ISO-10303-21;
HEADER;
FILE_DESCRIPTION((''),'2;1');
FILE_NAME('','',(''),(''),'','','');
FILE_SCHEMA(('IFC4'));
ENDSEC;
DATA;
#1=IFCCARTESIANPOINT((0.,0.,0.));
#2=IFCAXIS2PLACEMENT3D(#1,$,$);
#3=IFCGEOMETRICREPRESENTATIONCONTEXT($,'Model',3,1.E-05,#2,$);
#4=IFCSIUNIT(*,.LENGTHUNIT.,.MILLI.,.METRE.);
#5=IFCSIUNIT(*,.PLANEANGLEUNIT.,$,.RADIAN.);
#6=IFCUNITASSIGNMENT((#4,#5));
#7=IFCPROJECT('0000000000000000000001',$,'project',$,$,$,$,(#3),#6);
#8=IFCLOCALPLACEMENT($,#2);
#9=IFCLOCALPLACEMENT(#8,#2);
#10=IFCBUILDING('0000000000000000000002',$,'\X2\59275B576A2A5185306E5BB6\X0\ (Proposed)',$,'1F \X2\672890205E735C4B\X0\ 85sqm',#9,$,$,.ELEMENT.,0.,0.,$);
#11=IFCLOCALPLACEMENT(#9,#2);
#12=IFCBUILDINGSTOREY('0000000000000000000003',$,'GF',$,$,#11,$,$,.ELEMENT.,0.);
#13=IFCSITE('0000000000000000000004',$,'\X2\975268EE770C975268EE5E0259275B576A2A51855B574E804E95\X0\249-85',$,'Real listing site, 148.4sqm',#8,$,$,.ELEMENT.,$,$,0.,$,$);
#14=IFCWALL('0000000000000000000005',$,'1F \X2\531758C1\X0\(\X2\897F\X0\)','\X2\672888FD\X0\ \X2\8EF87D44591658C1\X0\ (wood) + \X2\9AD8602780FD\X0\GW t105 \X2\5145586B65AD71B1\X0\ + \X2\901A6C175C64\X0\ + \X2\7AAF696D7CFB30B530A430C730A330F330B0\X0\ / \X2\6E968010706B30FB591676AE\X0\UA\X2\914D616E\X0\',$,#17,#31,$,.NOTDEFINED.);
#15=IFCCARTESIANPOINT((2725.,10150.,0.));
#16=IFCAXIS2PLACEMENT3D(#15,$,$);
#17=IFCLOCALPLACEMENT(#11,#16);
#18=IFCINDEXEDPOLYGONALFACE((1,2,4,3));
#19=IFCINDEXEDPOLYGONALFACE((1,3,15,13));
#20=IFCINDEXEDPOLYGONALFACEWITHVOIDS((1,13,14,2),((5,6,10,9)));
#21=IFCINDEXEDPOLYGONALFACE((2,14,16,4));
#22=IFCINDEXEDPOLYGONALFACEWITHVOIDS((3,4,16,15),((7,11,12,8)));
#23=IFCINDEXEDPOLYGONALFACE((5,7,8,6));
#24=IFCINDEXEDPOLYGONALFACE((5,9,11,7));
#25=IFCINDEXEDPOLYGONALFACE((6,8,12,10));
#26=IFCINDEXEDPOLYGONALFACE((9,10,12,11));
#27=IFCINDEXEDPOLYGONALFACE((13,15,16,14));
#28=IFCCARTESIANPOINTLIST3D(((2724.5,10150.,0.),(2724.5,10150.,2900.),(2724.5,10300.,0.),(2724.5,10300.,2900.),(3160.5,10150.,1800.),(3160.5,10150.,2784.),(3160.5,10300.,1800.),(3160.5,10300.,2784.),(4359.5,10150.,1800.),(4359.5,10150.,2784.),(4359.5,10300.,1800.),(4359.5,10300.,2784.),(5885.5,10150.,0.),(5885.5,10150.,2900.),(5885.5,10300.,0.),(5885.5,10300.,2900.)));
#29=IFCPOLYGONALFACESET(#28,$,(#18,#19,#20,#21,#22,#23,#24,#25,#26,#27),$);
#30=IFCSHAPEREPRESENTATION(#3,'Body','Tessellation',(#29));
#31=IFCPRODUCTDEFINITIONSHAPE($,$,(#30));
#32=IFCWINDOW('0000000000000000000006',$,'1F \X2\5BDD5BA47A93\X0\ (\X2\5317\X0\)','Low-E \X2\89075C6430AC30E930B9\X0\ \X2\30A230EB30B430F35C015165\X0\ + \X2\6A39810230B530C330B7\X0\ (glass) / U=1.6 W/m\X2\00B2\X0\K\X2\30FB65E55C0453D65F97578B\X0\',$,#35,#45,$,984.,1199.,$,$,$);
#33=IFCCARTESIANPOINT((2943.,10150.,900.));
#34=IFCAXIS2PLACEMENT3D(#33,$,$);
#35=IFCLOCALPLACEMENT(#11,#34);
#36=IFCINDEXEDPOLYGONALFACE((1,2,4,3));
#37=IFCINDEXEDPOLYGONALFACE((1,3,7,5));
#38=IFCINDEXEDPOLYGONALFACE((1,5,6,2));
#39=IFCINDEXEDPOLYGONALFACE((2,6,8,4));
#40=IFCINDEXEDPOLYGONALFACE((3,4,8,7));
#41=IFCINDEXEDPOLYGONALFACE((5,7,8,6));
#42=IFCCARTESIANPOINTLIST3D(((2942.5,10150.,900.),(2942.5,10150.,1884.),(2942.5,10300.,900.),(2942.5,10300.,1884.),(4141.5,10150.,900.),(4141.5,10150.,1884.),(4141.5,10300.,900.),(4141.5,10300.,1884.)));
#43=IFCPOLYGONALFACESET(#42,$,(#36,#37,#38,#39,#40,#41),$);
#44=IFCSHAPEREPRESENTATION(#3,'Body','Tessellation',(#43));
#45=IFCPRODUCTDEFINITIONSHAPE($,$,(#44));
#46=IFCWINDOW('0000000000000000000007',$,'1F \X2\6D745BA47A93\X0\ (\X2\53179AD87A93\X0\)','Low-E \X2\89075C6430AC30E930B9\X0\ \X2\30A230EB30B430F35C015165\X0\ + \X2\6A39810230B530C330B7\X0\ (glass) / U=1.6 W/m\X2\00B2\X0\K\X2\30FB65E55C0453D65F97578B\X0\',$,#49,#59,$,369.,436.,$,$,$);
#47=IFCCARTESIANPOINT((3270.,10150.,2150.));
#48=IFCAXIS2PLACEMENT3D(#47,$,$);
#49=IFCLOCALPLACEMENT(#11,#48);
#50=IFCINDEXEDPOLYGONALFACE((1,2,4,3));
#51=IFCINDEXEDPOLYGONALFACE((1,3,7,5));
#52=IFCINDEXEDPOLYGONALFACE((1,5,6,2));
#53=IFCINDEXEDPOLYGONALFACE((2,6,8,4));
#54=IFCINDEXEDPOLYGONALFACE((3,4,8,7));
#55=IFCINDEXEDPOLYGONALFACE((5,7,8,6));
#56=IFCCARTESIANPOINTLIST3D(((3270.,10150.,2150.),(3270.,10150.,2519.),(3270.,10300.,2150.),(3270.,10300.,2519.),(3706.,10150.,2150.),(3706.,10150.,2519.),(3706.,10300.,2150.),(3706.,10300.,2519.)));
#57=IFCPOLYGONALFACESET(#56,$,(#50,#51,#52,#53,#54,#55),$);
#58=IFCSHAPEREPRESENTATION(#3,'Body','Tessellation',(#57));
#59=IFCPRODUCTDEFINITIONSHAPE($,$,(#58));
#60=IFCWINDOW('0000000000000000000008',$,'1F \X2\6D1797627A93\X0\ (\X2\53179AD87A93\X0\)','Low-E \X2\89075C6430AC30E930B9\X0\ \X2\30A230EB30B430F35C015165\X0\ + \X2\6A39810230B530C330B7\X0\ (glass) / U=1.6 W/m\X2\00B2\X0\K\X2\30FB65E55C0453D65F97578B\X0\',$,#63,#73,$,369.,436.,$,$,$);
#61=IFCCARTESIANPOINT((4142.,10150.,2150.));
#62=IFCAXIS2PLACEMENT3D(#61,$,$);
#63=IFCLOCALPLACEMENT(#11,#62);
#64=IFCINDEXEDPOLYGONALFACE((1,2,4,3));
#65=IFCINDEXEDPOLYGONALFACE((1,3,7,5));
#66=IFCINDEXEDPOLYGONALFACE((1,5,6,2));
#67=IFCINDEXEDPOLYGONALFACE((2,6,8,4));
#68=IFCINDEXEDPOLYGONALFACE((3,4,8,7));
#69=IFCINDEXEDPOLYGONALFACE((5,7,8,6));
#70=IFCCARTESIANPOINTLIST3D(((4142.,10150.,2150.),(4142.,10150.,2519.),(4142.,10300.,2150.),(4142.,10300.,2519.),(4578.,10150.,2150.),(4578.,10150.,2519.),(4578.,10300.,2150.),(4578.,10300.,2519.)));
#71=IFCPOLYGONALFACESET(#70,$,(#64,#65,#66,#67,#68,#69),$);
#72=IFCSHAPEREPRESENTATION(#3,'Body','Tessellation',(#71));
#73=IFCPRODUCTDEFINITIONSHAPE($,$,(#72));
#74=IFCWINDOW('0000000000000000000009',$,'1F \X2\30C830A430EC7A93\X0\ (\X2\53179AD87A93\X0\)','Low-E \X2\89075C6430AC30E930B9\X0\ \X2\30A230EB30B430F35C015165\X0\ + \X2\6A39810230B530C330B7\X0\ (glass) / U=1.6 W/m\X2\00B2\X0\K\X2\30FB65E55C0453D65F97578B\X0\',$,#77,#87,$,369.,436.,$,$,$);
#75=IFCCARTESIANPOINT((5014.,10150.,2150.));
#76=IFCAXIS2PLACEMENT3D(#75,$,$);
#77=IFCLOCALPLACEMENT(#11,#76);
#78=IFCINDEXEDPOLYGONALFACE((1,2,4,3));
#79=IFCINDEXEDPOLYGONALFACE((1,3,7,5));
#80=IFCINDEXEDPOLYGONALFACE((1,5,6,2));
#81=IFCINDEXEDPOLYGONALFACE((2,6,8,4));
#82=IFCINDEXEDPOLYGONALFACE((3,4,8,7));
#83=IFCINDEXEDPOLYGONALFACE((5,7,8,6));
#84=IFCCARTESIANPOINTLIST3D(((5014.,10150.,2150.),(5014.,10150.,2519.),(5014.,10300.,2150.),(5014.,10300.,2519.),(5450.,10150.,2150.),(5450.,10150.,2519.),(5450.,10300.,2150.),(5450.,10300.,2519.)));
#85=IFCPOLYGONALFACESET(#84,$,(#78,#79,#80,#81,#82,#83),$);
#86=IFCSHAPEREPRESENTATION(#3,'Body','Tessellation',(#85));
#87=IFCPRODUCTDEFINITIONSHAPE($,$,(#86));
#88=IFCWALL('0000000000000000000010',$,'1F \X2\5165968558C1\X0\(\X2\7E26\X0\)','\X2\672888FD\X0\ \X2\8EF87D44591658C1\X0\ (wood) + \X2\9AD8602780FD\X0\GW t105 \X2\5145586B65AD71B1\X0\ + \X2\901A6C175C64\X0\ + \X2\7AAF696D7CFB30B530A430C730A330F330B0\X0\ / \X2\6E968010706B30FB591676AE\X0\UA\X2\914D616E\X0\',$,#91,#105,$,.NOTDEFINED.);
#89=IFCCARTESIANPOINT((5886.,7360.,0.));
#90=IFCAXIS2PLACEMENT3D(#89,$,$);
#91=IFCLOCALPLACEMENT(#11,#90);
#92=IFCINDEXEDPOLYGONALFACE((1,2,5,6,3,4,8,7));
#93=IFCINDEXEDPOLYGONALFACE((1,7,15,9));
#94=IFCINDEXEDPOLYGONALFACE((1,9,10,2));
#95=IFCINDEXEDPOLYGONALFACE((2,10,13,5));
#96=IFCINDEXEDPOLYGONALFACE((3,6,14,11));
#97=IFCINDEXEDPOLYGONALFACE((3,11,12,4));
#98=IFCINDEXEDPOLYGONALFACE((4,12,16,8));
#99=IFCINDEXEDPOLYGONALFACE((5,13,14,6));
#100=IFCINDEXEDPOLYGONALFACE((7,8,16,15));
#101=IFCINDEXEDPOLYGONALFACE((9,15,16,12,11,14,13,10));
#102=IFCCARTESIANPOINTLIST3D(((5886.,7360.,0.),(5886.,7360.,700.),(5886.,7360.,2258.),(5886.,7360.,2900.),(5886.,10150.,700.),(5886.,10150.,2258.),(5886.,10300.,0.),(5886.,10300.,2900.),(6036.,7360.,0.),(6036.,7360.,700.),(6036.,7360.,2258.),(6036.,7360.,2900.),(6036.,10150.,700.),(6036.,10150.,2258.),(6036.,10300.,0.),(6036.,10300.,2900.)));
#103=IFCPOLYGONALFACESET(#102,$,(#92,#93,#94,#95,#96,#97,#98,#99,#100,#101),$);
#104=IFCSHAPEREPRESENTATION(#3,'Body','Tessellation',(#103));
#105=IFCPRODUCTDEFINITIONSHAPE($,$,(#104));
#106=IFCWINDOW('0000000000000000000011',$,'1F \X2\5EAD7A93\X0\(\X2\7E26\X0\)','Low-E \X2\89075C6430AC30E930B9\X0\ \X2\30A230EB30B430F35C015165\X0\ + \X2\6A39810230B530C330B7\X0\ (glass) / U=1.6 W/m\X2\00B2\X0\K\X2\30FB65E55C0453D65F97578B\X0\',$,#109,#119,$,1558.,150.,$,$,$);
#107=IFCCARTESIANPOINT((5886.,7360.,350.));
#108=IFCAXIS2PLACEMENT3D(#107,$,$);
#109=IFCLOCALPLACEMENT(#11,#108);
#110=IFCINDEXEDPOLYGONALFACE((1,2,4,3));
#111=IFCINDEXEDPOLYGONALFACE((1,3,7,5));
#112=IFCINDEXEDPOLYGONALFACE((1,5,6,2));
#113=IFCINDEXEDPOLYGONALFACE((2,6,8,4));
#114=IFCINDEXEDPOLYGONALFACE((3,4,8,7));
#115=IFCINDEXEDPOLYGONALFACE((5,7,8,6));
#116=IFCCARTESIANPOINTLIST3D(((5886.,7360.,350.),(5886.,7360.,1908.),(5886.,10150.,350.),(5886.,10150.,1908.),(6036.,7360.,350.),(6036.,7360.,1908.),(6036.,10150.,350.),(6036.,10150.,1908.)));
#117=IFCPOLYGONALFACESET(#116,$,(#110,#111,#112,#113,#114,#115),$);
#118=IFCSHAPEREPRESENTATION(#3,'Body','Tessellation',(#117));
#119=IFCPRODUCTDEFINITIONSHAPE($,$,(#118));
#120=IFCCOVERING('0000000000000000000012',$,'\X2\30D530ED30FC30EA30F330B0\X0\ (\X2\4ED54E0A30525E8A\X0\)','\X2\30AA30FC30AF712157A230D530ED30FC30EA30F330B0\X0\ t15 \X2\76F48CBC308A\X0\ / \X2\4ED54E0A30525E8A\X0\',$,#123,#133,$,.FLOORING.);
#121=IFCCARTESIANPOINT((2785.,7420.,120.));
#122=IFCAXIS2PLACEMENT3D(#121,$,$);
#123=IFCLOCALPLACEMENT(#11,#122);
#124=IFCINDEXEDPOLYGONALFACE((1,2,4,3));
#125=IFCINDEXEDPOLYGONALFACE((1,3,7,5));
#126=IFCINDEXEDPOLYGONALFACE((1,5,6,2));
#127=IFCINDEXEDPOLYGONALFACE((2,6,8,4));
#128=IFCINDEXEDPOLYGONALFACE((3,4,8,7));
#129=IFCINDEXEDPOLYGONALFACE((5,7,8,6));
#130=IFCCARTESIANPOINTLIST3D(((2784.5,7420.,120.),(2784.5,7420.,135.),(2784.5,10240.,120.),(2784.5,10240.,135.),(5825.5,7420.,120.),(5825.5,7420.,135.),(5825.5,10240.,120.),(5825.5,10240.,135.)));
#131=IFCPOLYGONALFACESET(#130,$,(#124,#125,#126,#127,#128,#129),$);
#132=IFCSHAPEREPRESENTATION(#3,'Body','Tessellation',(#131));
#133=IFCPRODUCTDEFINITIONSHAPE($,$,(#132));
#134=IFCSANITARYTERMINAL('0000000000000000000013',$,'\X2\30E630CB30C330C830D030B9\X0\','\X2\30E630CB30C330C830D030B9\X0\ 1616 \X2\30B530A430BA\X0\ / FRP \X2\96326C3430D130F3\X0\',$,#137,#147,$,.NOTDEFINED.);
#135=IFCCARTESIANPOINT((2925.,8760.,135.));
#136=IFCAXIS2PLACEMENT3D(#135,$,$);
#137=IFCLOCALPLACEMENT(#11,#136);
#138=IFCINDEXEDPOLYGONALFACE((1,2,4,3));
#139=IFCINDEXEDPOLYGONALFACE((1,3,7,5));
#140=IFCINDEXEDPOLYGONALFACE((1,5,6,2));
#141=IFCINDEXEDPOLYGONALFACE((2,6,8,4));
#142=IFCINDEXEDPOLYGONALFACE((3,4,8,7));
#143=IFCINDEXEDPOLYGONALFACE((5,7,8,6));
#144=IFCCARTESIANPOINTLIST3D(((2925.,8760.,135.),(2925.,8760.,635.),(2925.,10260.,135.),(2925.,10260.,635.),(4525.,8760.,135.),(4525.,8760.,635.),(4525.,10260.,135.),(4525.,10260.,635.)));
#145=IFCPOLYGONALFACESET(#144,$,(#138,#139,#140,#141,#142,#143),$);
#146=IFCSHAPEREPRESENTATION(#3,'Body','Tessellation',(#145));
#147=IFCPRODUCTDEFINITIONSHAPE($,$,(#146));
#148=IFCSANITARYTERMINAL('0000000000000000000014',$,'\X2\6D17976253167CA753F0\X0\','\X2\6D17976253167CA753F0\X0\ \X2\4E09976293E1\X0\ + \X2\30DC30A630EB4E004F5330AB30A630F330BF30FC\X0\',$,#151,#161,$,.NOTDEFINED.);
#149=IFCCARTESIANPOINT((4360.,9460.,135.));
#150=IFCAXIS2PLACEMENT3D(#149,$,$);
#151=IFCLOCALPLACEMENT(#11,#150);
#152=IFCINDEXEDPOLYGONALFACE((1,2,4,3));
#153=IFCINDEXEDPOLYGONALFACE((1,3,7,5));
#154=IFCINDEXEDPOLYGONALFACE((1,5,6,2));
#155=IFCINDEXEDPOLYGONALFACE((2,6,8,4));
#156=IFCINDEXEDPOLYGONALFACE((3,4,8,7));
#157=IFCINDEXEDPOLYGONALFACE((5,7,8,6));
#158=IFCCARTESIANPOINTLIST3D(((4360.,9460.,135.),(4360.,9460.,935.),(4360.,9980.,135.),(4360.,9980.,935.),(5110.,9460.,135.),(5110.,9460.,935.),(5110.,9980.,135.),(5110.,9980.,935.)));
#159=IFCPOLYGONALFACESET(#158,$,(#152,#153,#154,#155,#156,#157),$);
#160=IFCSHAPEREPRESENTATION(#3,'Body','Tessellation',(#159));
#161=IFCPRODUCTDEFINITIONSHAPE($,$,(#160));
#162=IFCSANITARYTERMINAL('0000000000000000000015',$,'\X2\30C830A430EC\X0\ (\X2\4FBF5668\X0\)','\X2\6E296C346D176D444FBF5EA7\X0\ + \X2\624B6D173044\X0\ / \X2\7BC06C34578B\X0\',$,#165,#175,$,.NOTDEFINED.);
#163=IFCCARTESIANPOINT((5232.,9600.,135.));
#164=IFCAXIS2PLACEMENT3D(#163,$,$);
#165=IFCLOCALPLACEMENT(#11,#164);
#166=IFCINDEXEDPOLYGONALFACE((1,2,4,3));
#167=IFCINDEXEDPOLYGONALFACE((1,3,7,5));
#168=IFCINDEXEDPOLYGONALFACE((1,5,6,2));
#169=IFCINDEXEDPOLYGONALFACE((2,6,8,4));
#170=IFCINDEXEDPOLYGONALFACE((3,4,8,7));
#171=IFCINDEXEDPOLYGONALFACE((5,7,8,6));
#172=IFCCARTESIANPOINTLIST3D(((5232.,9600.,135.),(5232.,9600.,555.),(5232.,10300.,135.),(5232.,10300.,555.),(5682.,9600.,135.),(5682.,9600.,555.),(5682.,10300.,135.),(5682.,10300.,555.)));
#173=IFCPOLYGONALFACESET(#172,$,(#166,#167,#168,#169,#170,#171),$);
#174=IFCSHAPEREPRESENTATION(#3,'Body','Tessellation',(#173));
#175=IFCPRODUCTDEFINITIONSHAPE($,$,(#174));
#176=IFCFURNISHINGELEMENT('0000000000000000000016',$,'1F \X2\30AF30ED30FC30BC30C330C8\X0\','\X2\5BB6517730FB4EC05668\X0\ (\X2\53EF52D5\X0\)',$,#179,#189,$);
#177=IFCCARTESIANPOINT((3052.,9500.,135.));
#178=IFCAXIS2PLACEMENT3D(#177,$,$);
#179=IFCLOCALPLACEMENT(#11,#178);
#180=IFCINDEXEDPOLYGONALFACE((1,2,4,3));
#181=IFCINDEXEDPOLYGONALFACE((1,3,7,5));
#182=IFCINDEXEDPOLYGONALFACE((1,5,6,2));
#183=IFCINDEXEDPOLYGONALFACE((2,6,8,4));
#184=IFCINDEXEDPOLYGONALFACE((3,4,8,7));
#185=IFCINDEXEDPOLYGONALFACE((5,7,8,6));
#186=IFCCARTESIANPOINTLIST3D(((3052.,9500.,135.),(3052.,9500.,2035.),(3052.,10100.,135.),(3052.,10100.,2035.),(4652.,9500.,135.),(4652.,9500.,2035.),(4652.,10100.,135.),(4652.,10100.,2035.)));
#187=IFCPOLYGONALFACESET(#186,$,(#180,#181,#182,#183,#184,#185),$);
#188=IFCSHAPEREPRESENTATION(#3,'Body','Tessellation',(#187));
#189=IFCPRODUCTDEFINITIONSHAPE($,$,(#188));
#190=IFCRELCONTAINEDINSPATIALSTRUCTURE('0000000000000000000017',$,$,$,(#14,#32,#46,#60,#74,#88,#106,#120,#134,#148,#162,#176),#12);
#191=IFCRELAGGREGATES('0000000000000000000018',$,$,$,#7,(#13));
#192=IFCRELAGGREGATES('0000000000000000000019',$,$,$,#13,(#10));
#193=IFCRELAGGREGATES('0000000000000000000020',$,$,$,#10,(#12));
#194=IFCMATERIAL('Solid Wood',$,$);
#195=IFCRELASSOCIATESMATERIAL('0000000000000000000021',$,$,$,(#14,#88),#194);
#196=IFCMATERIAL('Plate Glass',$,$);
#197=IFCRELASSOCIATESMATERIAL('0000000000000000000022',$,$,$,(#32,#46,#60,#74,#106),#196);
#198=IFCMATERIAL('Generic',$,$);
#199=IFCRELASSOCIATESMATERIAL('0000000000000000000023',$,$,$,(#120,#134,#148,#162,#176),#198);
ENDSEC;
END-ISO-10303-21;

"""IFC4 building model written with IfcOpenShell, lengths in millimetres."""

from ifc_helpers import new_model, si_unit, frame, frame_2d, origin, place, context, project, spatial, rectangle, extrude, material, element, fill, save


model = new_model("IFC4")

# Units and contexts
model_context = context("Model", 3, precision=1e-05, world=origin())
ifc_project = project(units=[si_unit("LENGTHUNIT", "METRE", prefix="MILLI"), si_unit("PLANEANGLEUNIT", "RADIAN")], contexts=[model_context])

# Site, building, storey
site_placement = place(None, origin())
site = spatial("IfcSite", under=ifc_project, at=site_placement, Name="青森県青森市大字横内字亀井249-85", ObjectType="Real listing site, 148.4sqm", CompositionType="ELEMENT", RefElevation=0.0)
building_placement = place(site_placement, origin())
building = spatial("IfcBuilding", under=site, at=building_placement, Name="大字横内の家 (Proposed)", ObjectType="1F 木造平屋 85sqm", CompositionType="ELEMENT", ElevationOfRefHeight=0.0, ElevationOfTerrain=0.0)
storey_placement = place(building_placement, origin())
storey = spatial("IfcBuildingStorey", under=building, at=storey_placement, Name="GF", CompositionType="ELEMENT", Elevation=0.0)

# Shared definitions
ifc_material_1 = material(Name="Solid Wood")

# Wall, openings, windows
wall_1_placement = place(storey_placement, frame((2725.0, 10150.0, 0.0)))
wall_1 = element("IfcWall", 1, at=wall_1_placement, inside=storey, material=ifc_material_1, Name="1F 北壁(西)", Description="木製 軸組外壁 (wood) + 高性能GW t105 充填断熱 + 通気層 + 窯業系サイディング / 準耐火・外皮UA配慮", PredefinedType="NOTDEFINED", context=model_context, shape_type="SweptSolid", body=[
    extrude(rectangle(XDim=3161.0, YDim=150.0, at=frame_2d((1580.0, 75.0))), frame((2725.0, 10150.0, 0.0)), (0.0, 0.0, 1.0), 2900.0),
])
opening_1_placement = place(storey_placement, frame((2943.0, 10150.0, 900.0)))
opening_1 = element("IfcOpeningElement", 2, at=opening_1_placement, cuts=wall_1, PredefinedType="NOTDEFINED", context=model_context, shape_type="SweptSolid", body=[
    extrude(rectangle(XDim=1199.0, YDim=150.0, at=frame_2d((599.0, 75.0))), frame((2943.0, 10150.0, 900.0)), (0.0, 0.0, 1.0), 984.0),
])
opening_2_placement = place(storey_placement, frame((3270.0, 10150.0, 2150.0)))
opening_2 = element("IfcOpeningElement", 3, at=opening_2_placement, cuts=wall_1, PredefinedType="NOTDEFINED", context=model_context, shape_type="SweptSolid", body=[
    extrude(rectangle(XDim=436.0, YDim=150.0, at=frame_2d((218.0, 75.0))), frame((3270.0, 10150.0, 2150.0)), (0.0, 0.0, 1.0), 369.0),
])
opening_3_placement = place(storey_placement, frame((4142.0, 10150.0, 2150.0)))
opening_3 = element("IfcOpeningElement", 4, at=opening_3_placement, cuts=wall_1, PredefinedType="NOTDEFINED", context=model_context, shape_type="SweptSolid", body=[
    extrude(rectangle(XDim=436.0, YDim=150.0, at=frame_2d((218.0, 75.0))), frame((4142.0, 10150.0, 2150.0)), (0.0, 0.0, 1.0), 369.0),
])
opening_4_placement = place(storey_placement, frame((5014.0, 10150.0, 2150.0)))
opening_4 = element("IfcOpeningElement", 5, at=opening_4_placement, cuts=wall_1, PredefinedType="NOTDEFINED", context=model_context, shape_type="SweptSolid", body=[
    extrude(rectangle(XDim=436.0, YDim=150.0, at=frame_2d((218.0, 75.0))), frame((5014.0, 10150.0, 2150.0)), (0.0, 0.0, 1.0), 369.0),
])
ifc_material_2 = material(Name="Plate Glass")
window_1_placement = place(storey_placement, frame((2943.0, 10150.0, 900.0)))
window_1 = element("IfcWindow", 6, at=window_1_placement, inside=storey, material=ifc_material_2, Name="1F 寝室窓 (北)", Description="Low-E 複層ガラス アルゴン封入 + 樹脂サッシ (glass) / U=1.6 W/m²K・日射取得型", OverallHeight=984.0, OverallWidth=1199.0, context=model_context, shape_type="SweptSolid", body=[
    extrude(rectangle(XDim=1199.0, YDim=150.0, at=frame_2d((599.0, 75.0))), frame((2943.0, 10150.0, 900.0)), (0.0, 0.0, 1.0), 984.0),
])
fill(opening_1, window_1)
window_2_placement = place(storey_placement, frame((3270.0, 10150.0, 2150.0)))
window_2 = element("IfcWindow", 7, at=window_2_placement, inside=storey, material=ifc_material_2, Name="1F 浴室窓 (北高窓)", Description="Low-E 複層ガラス アルゴン封入 + 樹脂サッシ (glass) / U=1.6 W/m²K・日射取得型", OverallHeight=369.0, OverallWidth=436.0, context=model_context, shape_type="SweptSolid", body=[
    extrude(rectangle(XDim=436.0, YDim=150.0, at=frame_2d((218.0, 75.0))), frame((3270.0, 10150.0, 2150.0)), (0.0, 0.0, 1.0), 369.0),
])
fill(opening_2, window_2)
window_3_placement = place(storey_placement, frame((4142.0, 10150.0, 2150.0)))
window_3 = element("IfcWindow", 8, at=window_3_placement, inside=storey, material=ifc_material_2, Name="1F 洗面窓 (北高窓)", Description="Low-E 複層ガラス アルゴン封入 + 樹脂サッシ (glass) / U=1.6 W/m²K・日射取得型", OverallHeight=369.0, OverallWidth=436.0, context=model_context, shape_type="SweptSolid", body=[
    extrude(rectangle(XDim=436.0, YDim=150.0, at=frame_2d((218.0, 75.0))), frame((4142.0, 10150.0, 2150.0)), (0.0, 0.0, 1.0), 369.0),
])
fill(opening_3, window_3)
window_4_placement = place(storey_placement, frame((5014.0, 10150.0, 2150.0)))
window_4 = element("IfcWindow", 9, at=window_4_placement, inside=storey, material=ifc_material_2, Name="1F トイレ窓 (北高窓)", Description="Low-E 複層ガラス アルゴン封入 + 樹脂サッシ (glass) / U=1.6 W/m²K・日射取得型", OverallHeight=369.0, OverallWidth=436.0, context=model_context, shape_type="SweptSolid", body=[
    extrude(rectangle(XDim=436.0, YDim=150.0, at=frame_2d((218.0, 75.0))), frame((5014.0, 10150.0, 2150.0)), (0.0, 0.0, 1.0), 369.0),
])
fill(opening_4, window_4)

# Wall, opening, window
wall_2_placement = place(storey_placement, frame((5886.0, 7360.0, 0.0)))
wall_2 = element("IfcWall", 10, at=wall_2_placement, inside=storey, material=ifc_material_1, Name="1F 入隅壁(縦)", Description="木製 軸組外壁 (wood) + 高性能GW t105 充填断熱 + 通気層 + 窯業系サイディング / 準耐火・外皮UA配慮", PredefinedType="NOTDEFINED", context=model_context, shape_type="SweptSolid", body=[
    extrude(rectangle(XDim=150.0, YDim=2940.0, at=frame_2d((75.0, 1470.0))), frame((5886.0, 7360.0, 0.0)), (0.0, 0.0, 1.0), 2900.0),
])
opening_5_placement = place(storey_placement, frame((5886.0, 7360.0, 350.0)))
opening_5 = element("IfcOpeningElement", 11, at=opening_5_placement, cuts=wall_2, PredefinedType="NOTDEFINED", context=model_context, shape_type="SweptSolid", body=[
    extrude(rectangle(XDim=150.0, YDim=2790.0, at=frame_2d((75.0, 1395.0))), frame((5886.0, 7360.0, 350.0)), (0.0, 0.0, 1.0), 1558.0),
])
window_5_placement = place(storey_placement, frame((5886.0, 7360.0, 350.0)))
window_5 = element("IfcWindow", 12, at=window_5_placement, inside=storey, material=ifc_material_2, Name="1F 庭窓(縦)", Description="Low-E 複層ガラス アルゴン封入 + 樹脂サッシ (glass) / U=1.6 W/m²K・日射取得型", OverallHeight=1558.0, OverallWidth=150.0, context=model_context, shape_type="SweptSolid", body=[
    extrude(rectangle(XDim=150.0, YDim=2790.0, at=frame_2d((75.0, 1395.0))), frame((5886.0, 7360.0, 350.0)), (0.0, 0.0, 1.0), 1558.0),
])
fill(opening_5, window_5)

# Covering
ifc_material_3 = material(Name="Generic")
covering_placement = place(storey_placement, frame((2785.0, 7420.0, 120.0)))
element("IfcCovering", 13, at=covering_placement, inside=storey, material=ifc_material_3, Name="フローリング (仕上げ床)", Description="オーク無垢フローリング t15 直貼り / 仕上げ床", PredefinedType="FLOORING", context=model_context, shape_type="SweptSolid", body=[
    extrude(rectangle(XDim=3041.0, YDim=2820.0, at=frame_2d((1520.0, 1410.0))), frame((2785.0, 7420.0, 120.0)), (0.0, 0.0, 1.0), 15.0),
])

# Sanitary terminals
sanitary_terminal_1_placement = place(storey_placement, frame((2925.0, 8760.0, 135.0)))
element("IfcSanitaryTerminal", 14, at=sanitary_terminal_1_placement, inside=storey, material=ifc_material_3, Name="ユニットバス", Description="ユニットバス 1616 サイズ / FRP 防水パン", PredefinedType="NOTDEFINED", context=model_context, shape_type="SweptSolid", body=[
    extrude(rectangle(XDim=1600.0, YDim=1500.0, at=frame_2d((800.0, 750.0))), frame((2925.0, 8760.0, 135.0)), (0.0, 0.0, 1.0), 500.0),
])
sanitary_terminal_2_placement = place(storey_placement, frame((4360.0, 9460.0, 135.0)))
element("IfcSanitaryTerminal", 15, at=sanitary_terminal_2_placement, inside=storey, material=ifc_material_3, Name="洗面化粧台", Description="洗面化粧台 三面鏡 + ボウル一体カウンター", PredefinedType="NOTDEFINED", context=model_context, shape_type="SweptSolid", body=[
    extrude(rectangle(XDim=750.0, YDim=520.0, at=frame_2d((375.0, 260.0))), frame((4360.0, 9460.0, 135.0)), (0.0, 0.0, 1.0), 800.0),
])
sanitary_terminal_3_placement = place(storey_placement, frame((5232.0, 9600.0, 135.0)))
element("IfcSanitaryTerminal", 16, at=sanitary_terminal_3_placement, inside=storey, material=ifc_material_3, Name="トイレ (便器)", Description="温水洗浄便座 + 手洗い / 節水型", PredefinedType="NOTDEFINED", context=model_context, shape_type="SweptSolid", body=[
    extrude(rectangle(XDim=450.0, YDim=700.0, at=frame_2d((225.0, 350.0))), frame((5232.0, 9600.0, 135.0)), (0.0, 0.0, 1.0), 420.0),
])

# Furnishing element
furnishing_1_placement = place(storey_placement, frame((3052.0, 9500.0, 135.0)))
element("IfcFurnishingElement", 17, at=furnishing_1_placement, inside=storey, material=ifc_material_3, Name="1F クローゼット", Description="家具・什器 (可動)", context=model_context, shape_type="SweptSolid", body=[
    extrude(rectangle(XDim=1600.0, YDim=600.0, at=frame_2d((800.0, 300.0))), frame((3052.0, 9500.0, 135.0)), (0.0, 0.0, 1.0), 1900.0),
])

save(model, "model.ifc")
